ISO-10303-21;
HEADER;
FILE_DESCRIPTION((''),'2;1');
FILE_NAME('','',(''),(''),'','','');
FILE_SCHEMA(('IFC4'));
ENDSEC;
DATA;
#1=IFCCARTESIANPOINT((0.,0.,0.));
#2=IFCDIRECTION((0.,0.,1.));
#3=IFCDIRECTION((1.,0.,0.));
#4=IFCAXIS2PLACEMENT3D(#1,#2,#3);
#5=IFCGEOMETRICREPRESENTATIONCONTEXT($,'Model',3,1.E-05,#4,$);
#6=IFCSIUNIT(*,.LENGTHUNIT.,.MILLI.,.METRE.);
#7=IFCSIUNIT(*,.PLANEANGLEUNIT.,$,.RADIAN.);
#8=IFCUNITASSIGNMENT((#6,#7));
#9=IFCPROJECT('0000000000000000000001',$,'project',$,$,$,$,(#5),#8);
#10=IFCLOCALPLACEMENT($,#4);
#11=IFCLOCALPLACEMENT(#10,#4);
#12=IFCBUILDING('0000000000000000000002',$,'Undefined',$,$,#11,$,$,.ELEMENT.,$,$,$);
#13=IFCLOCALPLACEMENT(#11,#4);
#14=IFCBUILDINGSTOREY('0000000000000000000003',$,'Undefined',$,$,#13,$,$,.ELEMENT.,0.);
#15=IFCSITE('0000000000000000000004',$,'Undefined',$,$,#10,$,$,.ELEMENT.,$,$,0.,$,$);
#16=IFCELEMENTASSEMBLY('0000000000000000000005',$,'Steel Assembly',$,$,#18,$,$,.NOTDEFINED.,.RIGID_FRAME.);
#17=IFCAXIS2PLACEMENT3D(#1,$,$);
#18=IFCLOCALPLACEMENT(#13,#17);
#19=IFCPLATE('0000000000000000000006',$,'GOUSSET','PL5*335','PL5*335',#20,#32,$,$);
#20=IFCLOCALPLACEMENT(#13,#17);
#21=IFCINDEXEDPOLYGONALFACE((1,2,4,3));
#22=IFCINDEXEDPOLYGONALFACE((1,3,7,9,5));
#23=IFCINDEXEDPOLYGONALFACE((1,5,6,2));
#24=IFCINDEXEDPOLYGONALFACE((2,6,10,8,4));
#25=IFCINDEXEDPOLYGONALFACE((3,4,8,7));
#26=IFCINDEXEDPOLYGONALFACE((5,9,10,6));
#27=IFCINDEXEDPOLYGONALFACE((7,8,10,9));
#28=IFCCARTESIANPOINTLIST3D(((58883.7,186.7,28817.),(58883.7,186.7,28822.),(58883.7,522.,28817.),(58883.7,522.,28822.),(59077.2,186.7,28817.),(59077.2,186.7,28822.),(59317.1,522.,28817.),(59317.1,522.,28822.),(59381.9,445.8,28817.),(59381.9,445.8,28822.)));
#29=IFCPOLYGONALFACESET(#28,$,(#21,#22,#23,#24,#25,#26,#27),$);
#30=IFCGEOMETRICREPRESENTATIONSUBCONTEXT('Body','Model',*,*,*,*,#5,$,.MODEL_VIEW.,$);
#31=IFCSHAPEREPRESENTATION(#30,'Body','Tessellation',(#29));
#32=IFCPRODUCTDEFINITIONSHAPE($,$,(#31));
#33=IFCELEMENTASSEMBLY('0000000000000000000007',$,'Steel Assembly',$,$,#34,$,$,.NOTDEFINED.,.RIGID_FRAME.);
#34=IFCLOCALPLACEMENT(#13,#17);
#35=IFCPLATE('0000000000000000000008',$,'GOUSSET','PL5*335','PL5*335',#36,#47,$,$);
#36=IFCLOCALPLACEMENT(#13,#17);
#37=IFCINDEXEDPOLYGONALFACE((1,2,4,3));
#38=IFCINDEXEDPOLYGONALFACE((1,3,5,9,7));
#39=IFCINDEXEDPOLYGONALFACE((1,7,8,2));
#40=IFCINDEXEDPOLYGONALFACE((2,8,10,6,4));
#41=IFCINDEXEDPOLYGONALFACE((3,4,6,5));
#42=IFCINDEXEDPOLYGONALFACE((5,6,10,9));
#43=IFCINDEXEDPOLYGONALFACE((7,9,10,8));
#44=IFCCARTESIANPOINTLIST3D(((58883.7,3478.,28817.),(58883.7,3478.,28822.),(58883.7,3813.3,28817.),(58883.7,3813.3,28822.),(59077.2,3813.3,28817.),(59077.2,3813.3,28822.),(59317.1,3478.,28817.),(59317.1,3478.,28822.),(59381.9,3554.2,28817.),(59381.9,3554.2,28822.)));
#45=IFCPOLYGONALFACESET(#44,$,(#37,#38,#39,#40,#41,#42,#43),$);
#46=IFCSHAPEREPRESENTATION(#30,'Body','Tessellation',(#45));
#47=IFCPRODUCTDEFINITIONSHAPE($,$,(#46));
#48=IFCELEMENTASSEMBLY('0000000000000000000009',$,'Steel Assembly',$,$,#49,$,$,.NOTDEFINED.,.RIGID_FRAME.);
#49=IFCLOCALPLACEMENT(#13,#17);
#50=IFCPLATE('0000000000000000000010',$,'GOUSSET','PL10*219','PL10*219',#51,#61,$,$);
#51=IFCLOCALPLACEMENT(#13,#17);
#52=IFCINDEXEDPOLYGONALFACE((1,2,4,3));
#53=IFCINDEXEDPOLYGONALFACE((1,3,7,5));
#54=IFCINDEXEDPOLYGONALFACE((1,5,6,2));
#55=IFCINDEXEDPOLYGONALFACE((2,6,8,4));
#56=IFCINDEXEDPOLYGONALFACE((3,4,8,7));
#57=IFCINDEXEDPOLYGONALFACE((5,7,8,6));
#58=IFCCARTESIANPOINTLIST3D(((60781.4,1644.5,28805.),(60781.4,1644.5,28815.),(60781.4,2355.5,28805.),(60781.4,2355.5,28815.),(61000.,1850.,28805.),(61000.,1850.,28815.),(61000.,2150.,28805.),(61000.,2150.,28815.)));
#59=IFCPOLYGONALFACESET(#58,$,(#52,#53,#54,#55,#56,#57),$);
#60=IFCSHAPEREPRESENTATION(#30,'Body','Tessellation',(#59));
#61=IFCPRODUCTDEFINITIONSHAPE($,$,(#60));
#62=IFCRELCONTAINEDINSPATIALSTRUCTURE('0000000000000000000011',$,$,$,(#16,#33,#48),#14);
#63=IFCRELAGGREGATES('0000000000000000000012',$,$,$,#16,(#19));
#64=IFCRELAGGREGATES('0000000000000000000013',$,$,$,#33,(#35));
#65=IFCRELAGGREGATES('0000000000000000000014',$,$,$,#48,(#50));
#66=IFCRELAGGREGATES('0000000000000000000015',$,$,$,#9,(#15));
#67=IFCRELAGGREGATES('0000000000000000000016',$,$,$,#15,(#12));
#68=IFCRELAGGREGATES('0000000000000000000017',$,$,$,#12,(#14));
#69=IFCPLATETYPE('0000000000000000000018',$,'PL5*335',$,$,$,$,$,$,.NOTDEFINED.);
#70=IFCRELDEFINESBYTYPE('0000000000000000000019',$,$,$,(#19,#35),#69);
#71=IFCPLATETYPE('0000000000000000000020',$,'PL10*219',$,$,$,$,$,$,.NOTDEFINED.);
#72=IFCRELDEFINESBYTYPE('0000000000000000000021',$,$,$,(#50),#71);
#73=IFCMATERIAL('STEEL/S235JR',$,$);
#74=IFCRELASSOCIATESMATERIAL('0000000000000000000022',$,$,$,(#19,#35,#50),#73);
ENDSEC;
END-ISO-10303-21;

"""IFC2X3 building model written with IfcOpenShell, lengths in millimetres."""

from ifc_helpers import new_model, si_unit, frame, origin_with_axes, place, context, subcontext, project, spatial, polyline, outline, extrude, material, type_object, element, aggregate, save


model = new_model("IFC2X3")

# Units and contexts
model_context = context("Model", 3, precision=1e-05, world=origin_with_axes())
body_context = subcontext(model_context, "Body", "Model", "MODEL_VIEW")
ifc_project = project(units=[si_unit("LENGTHUNIT", "METRE", prefix="MILLI"), si_unit("PLANEANGLEUNIT", "RADIAN")], contexts=[model_context])

# Site, building, storey
site_placement = place(None, origin_with_axes())
site = spatial("IfcSite", under=ifc_project, at=site_placement, Name="Undefined", CompositionType="ELEMENT", RefElevation=0.0)
building_placement = place(site_placement, origin_with_axes())
building = spatial("IfcBuilding", under=site, at=building_placement, Name="Undefined", CompositionType="ELEMENT")
storey_placement = place(building_placement, origin_with_axes())
storey = spatial("IfcBuildingStorey", under=building, at=storey_placement, Name="Undefined", CompositionType="ELEMENT", Elevation=0.0)

# Shared definitions
ifc_material_1 = material(Name="STEEL/S235JR")

# Element assemblies, plates
assembly_1_placement = place(storey_placement, origin_with_axes())
assembly_1 = element("IfcElementAssembly", 1, at=assembly_1_placement, inside=storey, Name="Steel Assembly", AssemblyPlace="NOTDEFINED", PredefinedType="RIGID_FRAME")
plate_type_1 = type_object("IfcPlateType", Name="PL5*335", PredefinedType="NOTDEFINED")
plate_1_placement = place(assembly_1_placement, frame((58883.7, 186.7, 28819.5), z_axis=(0.0, 0.0, 1.0), x_axis=(1.0, 0.0, 0.0)))
plate_1 = element("IfcPlate", 2, at=plate_1_placement, type_object=plate_type_1, material=ifc_material_1, Name="GOUSSET", Description="PL5*335", ObjectType="PL5*335", context=body_context, shape_type="SweptSolid", body=[
    extrude(outline(polyline([(0.0, 0.0), (193.4, 0.0), (498.2, 259.1), (433.4, 335.3), (0.0, 335.3), (0.0, 0.0)])), frame((0.0, 0.0, -2.5), z_axis=(0.0, 0.0, 1.0), x_axis=(1.0, 0.0, 0.0)), (0.0, 0.0, 1.0), 5.0),
])
aggregate(assembly_1, [plate_1])
assembly_2_placement = place(storey_placement, origin_with_axes())
assembly_2 = element("IfcElementAssembly", 3, at=assembly_2_placement, inside=storey, Name="Steel Assembly", AssemblyPlace="NOTDEFINED", PredefinedType="RIGID_FRAME")
plate_2_placement = place(assembly_2_placement, frame((58883.7, 3813.3, 28819.5), z_axis=(0.0, 0.0, -1.0), x_axis=(1.0, 0.0, 0.0)))
plate_2 = element("IfcPlate", 4, at=plate_2_placement, type_object=plate_type_1, material=ifc_material_1, Name="GOUSSET", Description="PL5*335", ObjectType="PL5*335", context=body_context, shape_type="SweptSolid", body=[
    extrude(outline(polyline([(0.0, 0.0), (193.4, 0.0), (498.2, 259.1), (433.4, 335.3), (0.0, 335.3), (0.0, 0.0)])), frame((0.0, 0.0, -2.5), z_axis=(0.0, 0.0, 1.0), x_axis=(1.0, 0.0, 0.0)), (0.0, 0.0, 1.0), 5.0),
])
aggregate(assembly_2, [plate_2])
assembly_3_placement = place(storey_placement, origin_with_axes())
assembly_3 = element("IfcElementAssembly", 5, at=assembly_3_placement, inside=storey, Name="Steel Assembly", AssemblyPlace="NOTDEFINED", PredefinedType="RIGID_FRAME")
plate_type_2 = type_object("IfcPlateType", Name="PL10*219", PredefinedType="NOTDEFINED")
plate_3_placement = place(assembly_3_placement, frame((61000.0, 1850.0, 28810.0), z_axis=(0.0, 0.0, -1.0), x_axis=(-0.728628, -0.68491, 0.0)))
plate_3 = element("IfcPlate", 6, at=plate_3_placement, type_object=plate_type_2, material=ifc_material_1, Name="GOUSSET", Description="PL10*219", ObjectType="PL10*219", context=body_context, shape_type="SweptSolid", body=[
    extrude(outline(polyline([(0.0, 0.0), (300.0, 0.0), (-186.9, 518.0), (-205.5, 218.6), (0.0, 0.0)])), frame((0.0, 0.0, -5.0), z_axis=(0.0, 0.0, 1.0), x_axis=(1.0, 0.0, 0.0)), (0.0, 0.0, 1.0), 10.0),
])

aggregate(assembly_3, [plate_3])

save(model, "model.ifc")
